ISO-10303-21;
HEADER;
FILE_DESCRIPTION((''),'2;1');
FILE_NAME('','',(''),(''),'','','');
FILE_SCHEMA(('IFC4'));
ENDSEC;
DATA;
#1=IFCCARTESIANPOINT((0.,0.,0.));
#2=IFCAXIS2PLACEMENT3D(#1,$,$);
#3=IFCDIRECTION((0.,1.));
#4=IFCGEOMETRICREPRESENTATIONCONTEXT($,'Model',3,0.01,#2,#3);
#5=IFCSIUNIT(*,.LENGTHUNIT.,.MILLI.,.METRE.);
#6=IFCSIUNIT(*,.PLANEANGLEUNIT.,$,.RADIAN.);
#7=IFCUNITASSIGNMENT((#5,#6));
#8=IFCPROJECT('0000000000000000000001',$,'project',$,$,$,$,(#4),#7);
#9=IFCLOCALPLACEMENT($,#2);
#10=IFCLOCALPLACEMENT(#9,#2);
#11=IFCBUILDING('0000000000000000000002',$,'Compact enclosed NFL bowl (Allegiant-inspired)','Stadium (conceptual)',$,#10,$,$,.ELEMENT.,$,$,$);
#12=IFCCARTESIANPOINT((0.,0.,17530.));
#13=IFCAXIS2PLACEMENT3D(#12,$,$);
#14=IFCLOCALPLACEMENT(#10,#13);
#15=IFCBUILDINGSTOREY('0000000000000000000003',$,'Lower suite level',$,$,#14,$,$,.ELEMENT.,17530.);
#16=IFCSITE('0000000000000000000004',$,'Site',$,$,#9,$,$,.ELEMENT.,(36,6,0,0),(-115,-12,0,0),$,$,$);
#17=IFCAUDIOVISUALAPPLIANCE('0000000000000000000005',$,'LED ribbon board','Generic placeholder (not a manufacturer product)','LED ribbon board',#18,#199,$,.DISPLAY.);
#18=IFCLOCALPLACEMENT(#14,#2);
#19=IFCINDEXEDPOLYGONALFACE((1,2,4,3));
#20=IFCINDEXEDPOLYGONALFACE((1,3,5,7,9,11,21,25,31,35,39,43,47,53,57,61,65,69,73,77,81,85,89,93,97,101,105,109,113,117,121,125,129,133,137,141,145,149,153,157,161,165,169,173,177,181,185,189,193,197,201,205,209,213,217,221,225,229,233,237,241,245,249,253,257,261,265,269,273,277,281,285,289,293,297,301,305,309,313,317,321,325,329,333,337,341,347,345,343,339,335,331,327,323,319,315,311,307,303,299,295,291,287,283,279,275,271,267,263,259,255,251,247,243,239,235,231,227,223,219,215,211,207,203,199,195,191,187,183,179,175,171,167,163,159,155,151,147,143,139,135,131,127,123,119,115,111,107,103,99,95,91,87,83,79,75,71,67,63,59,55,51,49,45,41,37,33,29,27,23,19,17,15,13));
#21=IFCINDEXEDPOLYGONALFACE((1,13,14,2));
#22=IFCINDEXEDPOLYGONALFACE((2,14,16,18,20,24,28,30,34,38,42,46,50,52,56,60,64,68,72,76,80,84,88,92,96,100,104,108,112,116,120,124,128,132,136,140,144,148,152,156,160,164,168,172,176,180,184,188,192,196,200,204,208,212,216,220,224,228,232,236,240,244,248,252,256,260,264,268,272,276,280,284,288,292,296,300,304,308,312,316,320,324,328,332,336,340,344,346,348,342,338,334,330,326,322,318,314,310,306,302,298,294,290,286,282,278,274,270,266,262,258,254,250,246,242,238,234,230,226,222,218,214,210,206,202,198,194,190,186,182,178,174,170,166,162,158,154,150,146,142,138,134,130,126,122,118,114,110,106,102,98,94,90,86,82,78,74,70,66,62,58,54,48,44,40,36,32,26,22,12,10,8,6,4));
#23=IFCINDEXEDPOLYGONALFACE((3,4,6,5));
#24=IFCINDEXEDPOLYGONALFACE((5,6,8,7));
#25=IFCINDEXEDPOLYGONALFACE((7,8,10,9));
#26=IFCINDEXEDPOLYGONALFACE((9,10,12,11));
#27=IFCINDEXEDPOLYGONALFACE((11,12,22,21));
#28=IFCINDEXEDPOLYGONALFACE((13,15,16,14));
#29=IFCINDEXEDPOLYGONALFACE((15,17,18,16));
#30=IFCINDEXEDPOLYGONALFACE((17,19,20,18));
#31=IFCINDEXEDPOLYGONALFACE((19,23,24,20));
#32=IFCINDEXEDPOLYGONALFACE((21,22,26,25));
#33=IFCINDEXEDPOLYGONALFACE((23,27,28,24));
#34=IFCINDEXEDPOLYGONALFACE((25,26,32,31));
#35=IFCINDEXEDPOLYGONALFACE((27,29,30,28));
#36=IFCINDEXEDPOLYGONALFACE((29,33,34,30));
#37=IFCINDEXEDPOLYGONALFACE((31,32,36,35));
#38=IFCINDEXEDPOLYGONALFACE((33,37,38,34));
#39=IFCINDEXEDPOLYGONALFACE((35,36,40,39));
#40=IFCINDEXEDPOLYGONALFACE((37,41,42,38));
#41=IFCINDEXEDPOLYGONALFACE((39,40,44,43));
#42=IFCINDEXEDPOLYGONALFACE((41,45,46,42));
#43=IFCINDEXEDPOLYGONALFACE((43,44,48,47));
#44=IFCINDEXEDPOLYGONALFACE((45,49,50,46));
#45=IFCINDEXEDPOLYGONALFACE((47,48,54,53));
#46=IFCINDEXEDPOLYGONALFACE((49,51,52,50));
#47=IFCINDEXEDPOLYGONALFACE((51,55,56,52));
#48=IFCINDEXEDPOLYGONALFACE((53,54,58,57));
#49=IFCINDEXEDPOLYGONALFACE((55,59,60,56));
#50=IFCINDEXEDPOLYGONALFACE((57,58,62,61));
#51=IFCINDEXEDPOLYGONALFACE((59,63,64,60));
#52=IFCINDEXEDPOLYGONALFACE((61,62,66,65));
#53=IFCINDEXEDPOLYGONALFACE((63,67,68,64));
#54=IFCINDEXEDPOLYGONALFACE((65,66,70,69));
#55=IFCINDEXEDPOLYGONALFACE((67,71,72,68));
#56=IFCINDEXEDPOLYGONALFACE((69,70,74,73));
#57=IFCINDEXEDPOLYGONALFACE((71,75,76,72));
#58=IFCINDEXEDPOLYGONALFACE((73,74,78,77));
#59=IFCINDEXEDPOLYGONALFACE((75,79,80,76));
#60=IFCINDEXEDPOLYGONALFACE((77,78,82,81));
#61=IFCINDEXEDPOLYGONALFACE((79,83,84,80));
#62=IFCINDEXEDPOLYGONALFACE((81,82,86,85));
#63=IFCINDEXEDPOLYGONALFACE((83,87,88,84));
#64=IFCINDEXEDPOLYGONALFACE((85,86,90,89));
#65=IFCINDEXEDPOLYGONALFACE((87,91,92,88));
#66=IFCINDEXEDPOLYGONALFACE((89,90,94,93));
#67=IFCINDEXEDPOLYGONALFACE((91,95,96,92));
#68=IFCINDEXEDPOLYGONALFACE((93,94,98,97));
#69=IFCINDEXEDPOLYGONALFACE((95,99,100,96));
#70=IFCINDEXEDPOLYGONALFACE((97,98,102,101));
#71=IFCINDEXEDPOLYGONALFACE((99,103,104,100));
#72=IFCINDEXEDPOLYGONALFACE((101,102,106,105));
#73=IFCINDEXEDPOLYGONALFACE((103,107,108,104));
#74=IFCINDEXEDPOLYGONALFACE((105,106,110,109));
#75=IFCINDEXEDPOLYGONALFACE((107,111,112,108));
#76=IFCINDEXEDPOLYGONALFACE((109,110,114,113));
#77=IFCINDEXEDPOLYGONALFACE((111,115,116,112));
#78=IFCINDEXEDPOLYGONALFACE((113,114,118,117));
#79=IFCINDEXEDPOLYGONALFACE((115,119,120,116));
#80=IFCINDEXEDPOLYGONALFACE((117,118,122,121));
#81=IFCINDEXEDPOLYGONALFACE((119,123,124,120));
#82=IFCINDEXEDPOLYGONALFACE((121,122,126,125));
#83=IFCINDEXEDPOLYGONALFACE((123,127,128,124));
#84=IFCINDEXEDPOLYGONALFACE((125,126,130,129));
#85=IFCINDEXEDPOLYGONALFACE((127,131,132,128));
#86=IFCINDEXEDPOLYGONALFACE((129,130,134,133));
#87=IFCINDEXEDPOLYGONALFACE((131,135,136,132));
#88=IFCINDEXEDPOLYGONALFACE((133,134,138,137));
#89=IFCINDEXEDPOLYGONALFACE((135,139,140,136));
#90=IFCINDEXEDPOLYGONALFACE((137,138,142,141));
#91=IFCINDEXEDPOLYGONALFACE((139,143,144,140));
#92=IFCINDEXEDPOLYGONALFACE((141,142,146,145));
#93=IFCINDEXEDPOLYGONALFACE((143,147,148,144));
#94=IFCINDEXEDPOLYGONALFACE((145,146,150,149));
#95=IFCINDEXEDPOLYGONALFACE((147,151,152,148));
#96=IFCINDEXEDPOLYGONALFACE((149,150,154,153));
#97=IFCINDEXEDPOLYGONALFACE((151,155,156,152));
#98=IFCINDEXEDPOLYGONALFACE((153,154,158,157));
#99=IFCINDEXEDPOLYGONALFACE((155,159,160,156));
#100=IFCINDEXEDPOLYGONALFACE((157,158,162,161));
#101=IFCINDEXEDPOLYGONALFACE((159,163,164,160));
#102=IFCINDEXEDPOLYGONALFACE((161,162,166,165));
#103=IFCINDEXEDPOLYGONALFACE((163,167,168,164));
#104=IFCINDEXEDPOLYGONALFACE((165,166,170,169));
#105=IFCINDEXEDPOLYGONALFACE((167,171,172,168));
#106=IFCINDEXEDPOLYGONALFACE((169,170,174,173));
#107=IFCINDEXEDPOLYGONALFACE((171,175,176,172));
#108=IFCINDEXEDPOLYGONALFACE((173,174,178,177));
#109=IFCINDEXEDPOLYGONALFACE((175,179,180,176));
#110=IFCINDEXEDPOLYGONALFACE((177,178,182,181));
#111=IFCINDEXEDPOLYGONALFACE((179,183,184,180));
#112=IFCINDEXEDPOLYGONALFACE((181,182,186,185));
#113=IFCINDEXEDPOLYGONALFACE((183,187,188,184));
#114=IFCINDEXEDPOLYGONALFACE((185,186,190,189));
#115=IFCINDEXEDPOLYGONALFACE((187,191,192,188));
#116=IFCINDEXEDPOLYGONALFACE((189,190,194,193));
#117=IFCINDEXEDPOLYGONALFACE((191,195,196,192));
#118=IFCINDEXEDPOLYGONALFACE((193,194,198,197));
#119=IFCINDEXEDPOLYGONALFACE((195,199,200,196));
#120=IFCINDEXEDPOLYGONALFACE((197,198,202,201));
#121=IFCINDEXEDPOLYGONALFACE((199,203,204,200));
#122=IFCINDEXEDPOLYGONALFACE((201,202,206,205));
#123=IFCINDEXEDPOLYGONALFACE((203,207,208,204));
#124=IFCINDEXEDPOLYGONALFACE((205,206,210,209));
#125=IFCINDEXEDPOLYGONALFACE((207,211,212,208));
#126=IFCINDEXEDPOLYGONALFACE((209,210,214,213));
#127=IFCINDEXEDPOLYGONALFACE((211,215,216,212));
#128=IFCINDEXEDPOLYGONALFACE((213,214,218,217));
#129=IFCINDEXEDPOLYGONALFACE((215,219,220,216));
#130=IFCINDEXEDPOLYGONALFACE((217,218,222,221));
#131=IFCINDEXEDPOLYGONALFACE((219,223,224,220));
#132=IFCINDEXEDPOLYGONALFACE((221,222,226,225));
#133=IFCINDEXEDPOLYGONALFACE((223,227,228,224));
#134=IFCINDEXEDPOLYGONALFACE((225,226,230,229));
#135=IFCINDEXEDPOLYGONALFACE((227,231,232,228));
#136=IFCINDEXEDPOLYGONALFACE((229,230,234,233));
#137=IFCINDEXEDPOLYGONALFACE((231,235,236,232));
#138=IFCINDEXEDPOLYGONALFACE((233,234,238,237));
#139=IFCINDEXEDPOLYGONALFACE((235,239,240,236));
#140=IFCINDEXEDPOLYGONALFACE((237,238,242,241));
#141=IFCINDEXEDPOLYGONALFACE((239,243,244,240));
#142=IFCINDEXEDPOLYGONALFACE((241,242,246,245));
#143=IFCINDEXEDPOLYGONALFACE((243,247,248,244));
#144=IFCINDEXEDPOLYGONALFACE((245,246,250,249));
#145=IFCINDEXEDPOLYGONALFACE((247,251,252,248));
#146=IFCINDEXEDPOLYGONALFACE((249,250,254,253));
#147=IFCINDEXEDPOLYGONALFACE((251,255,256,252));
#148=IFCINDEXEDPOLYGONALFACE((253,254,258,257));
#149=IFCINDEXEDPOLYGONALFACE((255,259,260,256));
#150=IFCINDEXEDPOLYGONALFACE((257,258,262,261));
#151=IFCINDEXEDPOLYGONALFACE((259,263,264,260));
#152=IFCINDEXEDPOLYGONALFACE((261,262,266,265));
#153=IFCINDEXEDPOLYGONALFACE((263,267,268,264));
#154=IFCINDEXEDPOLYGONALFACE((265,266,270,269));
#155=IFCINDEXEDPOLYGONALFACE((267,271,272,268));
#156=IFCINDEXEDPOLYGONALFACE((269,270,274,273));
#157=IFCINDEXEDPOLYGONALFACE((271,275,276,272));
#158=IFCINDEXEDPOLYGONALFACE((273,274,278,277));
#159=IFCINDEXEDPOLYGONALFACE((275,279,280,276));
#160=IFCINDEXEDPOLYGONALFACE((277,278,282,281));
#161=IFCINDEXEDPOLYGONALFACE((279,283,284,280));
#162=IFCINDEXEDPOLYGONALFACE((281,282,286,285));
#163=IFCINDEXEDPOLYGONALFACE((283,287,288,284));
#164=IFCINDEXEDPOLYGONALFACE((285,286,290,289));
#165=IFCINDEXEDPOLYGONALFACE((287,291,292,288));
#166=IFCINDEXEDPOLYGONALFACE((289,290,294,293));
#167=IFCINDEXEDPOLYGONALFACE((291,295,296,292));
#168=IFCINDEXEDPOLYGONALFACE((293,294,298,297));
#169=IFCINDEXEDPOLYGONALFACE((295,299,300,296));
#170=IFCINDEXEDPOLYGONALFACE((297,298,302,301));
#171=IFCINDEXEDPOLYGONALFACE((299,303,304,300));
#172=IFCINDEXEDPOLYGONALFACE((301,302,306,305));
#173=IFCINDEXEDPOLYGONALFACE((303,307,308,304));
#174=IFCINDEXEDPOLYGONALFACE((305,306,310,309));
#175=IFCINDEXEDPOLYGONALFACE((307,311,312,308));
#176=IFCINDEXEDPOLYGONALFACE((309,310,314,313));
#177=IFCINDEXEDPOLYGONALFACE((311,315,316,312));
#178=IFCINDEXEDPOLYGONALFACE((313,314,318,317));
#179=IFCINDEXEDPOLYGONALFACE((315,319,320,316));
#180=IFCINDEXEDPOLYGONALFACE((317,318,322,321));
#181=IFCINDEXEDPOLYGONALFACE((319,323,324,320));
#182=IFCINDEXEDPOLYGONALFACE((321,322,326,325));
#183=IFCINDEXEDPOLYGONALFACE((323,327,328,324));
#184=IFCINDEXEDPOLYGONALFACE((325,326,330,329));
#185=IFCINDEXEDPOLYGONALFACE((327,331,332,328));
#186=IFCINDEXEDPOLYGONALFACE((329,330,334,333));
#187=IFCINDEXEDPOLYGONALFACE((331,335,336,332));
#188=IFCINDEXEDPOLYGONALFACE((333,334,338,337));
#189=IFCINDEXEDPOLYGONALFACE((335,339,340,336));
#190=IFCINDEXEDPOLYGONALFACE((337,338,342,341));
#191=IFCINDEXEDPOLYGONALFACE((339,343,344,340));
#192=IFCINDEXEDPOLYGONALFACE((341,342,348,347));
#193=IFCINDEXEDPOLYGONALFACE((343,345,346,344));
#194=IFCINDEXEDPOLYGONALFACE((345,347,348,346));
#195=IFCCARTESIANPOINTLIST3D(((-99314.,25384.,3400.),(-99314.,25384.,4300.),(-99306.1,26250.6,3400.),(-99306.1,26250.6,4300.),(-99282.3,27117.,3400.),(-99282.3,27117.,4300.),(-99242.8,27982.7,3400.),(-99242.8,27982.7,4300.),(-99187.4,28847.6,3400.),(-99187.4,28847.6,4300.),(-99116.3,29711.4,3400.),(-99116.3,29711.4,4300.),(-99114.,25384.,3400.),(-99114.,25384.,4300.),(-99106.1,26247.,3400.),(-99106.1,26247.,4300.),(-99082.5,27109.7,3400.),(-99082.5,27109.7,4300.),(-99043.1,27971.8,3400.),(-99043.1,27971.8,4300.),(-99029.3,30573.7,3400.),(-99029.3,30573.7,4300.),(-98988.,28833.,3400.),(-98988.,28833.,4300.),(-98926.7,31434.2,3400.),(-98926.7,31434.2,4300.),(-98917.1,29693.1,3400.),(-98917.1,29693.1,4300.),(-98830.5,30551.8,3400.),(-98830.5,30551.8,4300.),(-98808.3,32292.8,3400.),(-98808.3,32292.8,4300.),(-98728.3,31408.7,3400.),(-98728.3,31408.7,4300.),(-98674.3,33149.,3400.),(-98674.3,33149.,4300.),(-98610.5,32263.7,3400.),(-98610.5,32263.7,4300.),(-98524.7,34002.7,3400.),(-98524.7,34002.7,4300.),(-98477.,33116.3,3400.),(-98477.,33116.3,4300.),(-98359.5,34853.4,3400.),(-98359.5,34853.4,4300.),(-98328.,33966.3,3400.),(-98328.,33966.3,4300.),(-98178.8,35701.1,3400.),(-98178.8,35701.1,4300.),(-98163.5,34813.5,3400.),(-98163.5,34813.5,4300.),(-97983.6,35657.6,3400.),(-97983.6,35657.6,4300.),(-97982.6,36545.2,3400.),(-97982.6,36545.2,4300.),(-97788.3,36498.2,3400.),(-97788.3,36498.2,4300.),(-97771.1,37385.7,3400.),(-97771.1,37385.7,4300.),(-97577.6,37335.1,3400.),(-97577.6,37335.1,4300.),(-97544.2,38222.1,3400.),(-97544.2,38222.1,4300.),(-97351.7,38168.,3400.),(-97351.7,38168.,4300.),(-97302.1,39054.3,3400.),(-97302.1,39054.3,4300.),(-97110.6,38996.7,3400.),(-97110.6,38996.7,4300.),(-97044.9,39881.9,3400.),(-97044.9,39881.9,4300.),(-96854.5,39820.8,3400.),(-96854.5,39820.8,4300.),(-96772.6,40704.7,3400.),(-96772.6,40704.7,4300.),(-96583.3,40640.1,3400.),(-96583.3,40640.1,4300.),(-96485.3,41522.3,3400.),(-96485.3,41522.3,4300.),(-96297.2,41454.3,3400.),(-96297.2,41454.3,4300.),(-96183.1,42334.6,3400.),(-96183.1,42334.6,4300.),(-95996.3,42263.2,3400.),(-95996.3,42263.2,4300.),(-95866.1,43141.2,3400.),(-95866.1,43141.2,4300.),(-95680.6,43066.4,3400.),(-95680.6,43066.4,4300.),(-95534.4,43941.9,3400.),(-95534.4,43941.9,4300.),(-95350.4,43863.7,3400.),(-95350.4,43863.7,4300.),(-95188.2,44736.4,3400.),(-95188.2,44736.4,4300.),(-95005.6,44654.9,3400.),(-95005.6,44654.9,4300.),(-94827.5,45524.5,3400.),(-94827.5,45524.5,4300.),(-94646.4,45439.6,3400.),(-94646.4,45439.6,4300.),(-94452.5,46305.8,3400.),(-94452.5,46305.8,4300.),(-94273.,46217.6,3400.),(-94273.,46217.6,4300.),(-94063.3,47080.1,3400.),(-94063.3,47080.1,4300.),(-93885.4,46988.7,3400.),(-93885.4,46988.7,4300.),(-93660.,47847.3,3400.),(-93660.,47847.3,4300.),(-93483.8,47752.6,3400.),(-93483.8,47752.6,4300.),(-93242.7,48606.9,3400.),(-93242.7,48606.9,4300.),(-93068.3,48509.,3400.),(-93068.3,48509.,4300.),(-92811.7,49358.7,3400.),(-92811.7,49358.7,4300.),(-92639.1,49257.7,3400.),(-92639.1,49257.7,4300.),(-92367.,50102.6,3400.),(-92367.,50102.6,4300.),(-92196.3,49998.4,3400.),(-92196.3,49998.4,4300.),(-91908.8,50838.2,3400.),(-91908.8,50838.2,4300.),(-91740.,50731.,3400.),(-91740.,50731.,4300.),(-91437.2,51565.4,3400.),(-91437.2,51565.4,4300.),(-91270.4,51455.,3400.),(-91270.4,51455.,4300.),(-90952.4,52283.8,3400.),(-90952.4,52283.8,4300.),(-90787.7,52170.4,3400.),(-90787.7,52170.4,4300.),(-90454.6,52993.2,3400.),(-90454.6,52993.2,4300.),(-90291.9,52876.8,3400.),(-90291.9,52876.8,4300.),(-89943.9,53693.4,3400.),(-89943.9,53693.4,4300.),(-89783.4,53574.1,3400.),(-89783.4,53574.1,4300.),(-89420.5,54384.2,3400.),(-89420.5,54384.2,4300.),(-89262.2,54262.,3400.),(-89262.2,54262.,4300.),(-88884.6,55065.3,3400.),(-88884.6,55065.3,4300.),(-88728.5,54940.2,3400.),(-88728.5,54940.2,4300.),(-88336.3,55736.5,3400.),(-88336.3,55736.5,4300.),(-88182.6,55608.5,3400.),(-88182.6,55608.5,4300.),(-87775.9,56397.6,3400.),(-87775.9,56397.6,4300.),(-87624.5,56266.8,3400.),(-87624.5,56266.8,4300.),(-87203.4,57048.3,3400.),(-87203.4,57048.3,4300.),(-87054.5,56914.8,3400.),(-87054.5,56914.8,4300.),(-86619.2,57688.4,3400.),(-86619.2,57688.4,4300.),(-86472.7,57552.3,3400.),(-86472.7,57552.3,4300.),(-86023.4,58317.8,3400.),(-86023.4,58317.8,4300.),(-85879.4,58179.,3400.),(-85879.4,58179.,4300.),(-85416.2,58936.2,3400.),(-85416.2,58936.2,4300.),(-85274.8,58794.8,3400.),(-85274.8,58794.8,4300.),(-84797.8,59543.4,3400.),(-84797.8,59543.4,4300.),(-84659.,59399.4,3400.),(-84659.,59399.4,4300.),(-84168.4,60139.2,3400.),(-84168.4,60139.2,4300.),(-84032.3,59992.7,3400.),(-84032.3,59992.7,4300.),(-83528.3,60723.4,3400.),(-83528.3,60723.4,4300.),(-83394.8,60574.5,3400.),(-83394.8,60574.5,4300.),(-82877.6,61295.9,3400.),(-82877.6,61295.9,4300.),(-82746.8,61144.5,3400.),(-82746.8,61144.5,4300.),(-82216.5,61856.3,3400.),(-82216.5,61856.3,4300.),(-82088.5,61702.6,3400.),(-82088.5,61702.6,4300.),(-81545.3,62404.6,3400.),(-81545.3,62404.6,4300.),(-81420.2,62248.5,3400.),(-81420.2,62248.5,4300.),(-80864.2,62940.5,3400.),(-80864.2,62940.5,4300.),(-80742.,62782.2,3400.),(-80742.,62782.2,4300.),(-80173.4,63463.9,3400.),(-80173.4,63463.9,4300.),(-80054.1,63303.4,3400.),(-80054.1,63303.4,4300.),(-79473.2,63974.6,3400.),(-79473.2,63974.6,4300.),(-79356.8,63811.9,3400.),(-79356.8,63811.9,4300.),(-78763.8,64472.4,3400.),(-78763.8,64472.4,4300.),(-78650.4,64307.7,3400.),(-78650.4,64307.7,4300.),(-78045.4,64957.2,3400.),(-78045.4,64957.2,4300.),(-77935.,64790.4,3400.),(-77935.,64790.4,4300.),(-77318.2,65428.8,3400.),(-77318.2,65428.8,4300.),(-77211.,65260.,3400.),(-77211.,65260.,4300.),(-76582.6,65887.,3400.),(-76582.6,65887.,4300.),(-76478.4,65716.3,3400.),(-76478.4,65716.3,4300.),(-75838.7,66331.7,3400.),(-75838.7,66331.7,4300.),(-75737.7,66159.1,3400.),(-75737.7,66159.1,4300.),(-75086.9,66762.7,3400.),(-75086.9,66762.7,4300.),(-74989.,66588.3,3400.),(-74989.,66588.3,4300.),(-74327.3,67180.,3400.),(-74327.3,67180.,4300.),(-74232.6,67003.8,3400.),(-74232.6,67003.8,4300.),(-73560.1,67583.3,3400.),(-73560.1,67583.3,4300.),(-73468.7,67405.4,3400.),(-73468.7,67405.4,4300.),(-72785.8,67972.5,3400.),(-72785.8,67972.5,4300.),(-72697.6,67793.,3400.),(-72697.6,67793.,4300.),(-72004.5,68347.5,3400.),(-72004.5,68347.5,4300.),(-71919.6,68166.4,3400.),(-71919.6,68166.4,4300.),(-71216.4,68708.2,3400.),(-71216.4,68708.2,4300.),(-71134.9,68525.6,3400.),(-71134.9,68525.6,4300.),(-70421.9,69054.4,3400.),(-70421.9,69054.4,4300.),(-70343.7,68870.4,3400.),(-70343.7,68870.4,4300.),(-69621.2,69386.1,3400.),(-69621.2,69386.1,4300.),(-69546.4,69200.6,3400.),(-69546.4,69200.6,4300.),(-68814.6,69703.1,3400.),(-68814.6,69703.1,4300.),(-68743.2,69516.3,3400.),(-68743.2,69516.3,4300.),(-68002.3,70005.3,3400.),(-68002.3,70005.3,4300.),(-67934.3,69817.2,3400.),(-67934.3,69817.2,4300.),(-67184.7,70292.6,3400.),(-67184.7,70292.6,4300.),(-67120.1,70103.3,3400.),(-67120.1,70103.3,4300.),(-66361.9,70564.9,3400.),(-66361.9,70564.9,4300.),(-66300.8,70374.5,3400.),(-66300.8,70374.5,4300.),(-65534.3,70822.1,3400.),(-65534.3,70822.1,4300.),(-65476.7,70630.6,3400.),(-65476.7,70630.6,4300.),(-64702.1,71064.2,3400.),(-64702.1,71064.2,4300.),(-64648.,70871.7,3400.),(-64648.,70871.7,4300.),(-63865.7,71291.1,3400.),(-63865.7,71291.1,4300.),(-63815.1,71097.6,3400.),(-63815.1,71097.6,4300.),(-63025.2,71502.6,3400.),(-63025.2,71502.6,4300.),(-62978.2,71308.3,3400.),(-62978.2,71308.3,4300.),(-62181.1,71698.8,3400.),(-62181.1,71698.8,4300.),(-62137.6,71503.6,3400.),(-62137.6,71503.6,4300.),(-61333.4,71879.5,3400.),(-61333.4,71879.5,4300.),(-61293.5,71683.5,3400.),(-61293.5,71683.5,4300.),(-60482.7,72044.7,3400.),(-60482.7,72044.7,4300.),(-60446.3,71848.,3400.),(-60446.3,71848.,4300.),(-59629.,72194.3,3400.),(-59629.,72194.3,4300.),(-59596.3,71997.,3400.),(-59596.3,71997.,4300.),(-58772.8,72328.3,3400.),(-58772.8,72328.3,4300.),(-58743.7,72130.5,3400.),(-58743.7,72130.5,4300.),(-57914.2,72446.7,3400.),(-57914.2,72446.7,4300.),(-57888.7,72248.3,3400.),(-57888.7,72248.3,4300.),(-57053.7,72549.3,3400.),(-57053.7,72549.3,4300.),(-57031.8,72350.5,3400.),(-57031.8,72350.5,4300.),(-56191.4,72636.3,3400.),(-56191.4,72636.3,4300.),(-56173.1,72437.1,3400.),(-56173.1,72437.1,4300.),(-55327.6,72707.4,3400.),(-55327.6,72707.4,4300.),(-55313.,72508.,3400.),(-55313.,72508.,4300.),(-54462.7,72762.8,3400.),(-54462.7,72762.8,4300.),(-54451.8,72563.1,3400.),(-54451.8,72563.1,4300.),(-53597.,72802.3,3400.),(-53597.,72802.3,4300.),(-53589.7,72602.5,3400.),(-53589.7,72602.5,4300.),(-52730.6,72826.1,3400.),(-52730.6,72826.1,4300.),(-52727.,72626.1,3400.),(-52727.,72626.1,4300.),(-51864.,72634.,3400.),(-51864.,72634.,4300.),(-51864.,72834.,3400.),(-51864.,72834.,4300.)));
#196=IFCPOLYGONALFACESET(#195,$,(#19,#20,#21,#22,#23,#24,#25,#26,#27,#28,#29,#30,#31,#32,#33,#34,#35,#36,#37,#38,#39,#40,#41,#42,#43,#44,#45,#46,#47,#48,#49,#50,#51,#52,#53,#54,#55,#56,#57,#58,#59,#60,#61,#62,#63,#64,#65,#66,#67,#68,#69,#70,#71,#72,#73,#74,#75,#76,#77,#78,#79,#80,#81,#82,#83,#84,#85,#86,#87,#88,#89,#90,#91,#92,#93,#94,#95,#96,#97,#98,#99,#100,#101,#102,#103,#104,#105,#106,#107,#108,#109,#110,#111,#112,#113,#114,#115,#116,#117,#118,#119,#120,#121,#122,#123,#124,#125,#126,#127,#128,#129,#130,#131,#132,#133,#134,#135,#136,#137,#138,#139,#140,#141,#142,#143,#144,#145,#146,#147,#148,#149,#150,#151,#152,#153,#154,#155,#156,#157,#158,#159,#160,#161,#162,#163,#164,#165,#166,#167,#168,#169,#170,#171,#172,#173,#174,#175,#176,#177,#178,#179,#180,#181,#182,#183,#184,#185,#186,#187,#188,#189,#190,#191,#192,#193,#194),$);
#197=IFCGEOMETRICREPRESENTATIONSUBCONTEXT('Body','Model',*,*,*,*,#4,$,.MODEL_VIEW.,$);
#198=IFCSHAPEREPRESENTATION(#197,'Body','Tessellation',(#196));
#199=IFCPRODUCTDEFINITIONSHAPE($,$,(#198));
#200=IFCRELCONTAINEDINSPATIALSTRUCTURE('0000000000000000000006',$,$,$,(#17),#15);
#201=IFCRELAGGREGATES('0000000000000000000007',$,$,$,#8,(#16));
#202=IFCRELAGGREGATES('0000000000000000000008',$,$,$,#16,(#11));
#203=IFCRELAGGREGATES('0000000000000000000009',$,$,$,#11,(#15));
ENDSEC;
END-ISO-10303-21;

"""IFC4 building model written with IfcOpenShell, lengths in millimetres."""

from ifc_helpers import new_model, si_unit, direction, frame, origin, place, context, subcontext, project, spatial, line, arc, indexed_curve, outline, extrude, element, save


model = new_model("IFC4")

# Units and contexts
model_context = context("Model", 3, precision=0.01, world=origin(), true_north=direction((0.0, 1.0)))
body_context = subcontext(model_context, "Body", "Model", "MODEL_VIEW")
ifc_project = project(units=[si_unit("LENGTHUNIT", "METRE", prefix="MILLI"), si_unit("PLANEANGLEUNIT", "RADIAN")], contexts=[model_context])

# Site, building, storey
site_placement = place(None, origin())
site = spatial("IfcSite", under=ifc_project, at=site_placement, Name="Site", CompositionType="ELEMENT", RefLatitude=(36, 6, 0, 0), RefLongitude=(-115, -12, 0, 0))
building_placement = place(site_placement, origin())
building = spatial("IfcBuilding", under=site, at=building_placement, Name="Compact enclosed NFL bowl (Allegiant-inspired)", Description="Stadium (conceptual)", CompositionType="ELEMENT")
storey_placement = place(building_placement, frame((0.0, 0.0, 17530.0)))
storey = spatial("IfcBuildingStorey", under=building, at=storey_placement, Name="Lower suite level", CompositionType="ELEMENT", Elevation=17530.0)

# Shared definitions
placement = place(storey_placement, frame((0.0, 0.0, -17530.0)))

# Audio visual appliance
element("IfcAudioVisualAppliance", 1, at=placement, inside=storey, Name="LED ribbon board", Description="Generic placeholder (not a manufacturer product)", ObjectType="LED ribbon board", PredefinedType="DISPLAY", context=body_context, shape_type="SweptSolid", body=[
    extrude(outline(indexed_curve([(-51864.0, 72634.0), (-85274.8, 58794.8), (-99114.0, 25384.0), (-99314.0, 25384.0), (-85416.2, 58936.2), (-51864.0, 72834.0)], segments=[arc(1, 2, 3), line(3, 4), arc(4, 5, 6), line(6, 1)], self_intersect=False)), frame((0.0, 0.0, 20930.0)), (0.0, 0.0, 1.0), 900.0),
])

save(model, "model.ifc")
